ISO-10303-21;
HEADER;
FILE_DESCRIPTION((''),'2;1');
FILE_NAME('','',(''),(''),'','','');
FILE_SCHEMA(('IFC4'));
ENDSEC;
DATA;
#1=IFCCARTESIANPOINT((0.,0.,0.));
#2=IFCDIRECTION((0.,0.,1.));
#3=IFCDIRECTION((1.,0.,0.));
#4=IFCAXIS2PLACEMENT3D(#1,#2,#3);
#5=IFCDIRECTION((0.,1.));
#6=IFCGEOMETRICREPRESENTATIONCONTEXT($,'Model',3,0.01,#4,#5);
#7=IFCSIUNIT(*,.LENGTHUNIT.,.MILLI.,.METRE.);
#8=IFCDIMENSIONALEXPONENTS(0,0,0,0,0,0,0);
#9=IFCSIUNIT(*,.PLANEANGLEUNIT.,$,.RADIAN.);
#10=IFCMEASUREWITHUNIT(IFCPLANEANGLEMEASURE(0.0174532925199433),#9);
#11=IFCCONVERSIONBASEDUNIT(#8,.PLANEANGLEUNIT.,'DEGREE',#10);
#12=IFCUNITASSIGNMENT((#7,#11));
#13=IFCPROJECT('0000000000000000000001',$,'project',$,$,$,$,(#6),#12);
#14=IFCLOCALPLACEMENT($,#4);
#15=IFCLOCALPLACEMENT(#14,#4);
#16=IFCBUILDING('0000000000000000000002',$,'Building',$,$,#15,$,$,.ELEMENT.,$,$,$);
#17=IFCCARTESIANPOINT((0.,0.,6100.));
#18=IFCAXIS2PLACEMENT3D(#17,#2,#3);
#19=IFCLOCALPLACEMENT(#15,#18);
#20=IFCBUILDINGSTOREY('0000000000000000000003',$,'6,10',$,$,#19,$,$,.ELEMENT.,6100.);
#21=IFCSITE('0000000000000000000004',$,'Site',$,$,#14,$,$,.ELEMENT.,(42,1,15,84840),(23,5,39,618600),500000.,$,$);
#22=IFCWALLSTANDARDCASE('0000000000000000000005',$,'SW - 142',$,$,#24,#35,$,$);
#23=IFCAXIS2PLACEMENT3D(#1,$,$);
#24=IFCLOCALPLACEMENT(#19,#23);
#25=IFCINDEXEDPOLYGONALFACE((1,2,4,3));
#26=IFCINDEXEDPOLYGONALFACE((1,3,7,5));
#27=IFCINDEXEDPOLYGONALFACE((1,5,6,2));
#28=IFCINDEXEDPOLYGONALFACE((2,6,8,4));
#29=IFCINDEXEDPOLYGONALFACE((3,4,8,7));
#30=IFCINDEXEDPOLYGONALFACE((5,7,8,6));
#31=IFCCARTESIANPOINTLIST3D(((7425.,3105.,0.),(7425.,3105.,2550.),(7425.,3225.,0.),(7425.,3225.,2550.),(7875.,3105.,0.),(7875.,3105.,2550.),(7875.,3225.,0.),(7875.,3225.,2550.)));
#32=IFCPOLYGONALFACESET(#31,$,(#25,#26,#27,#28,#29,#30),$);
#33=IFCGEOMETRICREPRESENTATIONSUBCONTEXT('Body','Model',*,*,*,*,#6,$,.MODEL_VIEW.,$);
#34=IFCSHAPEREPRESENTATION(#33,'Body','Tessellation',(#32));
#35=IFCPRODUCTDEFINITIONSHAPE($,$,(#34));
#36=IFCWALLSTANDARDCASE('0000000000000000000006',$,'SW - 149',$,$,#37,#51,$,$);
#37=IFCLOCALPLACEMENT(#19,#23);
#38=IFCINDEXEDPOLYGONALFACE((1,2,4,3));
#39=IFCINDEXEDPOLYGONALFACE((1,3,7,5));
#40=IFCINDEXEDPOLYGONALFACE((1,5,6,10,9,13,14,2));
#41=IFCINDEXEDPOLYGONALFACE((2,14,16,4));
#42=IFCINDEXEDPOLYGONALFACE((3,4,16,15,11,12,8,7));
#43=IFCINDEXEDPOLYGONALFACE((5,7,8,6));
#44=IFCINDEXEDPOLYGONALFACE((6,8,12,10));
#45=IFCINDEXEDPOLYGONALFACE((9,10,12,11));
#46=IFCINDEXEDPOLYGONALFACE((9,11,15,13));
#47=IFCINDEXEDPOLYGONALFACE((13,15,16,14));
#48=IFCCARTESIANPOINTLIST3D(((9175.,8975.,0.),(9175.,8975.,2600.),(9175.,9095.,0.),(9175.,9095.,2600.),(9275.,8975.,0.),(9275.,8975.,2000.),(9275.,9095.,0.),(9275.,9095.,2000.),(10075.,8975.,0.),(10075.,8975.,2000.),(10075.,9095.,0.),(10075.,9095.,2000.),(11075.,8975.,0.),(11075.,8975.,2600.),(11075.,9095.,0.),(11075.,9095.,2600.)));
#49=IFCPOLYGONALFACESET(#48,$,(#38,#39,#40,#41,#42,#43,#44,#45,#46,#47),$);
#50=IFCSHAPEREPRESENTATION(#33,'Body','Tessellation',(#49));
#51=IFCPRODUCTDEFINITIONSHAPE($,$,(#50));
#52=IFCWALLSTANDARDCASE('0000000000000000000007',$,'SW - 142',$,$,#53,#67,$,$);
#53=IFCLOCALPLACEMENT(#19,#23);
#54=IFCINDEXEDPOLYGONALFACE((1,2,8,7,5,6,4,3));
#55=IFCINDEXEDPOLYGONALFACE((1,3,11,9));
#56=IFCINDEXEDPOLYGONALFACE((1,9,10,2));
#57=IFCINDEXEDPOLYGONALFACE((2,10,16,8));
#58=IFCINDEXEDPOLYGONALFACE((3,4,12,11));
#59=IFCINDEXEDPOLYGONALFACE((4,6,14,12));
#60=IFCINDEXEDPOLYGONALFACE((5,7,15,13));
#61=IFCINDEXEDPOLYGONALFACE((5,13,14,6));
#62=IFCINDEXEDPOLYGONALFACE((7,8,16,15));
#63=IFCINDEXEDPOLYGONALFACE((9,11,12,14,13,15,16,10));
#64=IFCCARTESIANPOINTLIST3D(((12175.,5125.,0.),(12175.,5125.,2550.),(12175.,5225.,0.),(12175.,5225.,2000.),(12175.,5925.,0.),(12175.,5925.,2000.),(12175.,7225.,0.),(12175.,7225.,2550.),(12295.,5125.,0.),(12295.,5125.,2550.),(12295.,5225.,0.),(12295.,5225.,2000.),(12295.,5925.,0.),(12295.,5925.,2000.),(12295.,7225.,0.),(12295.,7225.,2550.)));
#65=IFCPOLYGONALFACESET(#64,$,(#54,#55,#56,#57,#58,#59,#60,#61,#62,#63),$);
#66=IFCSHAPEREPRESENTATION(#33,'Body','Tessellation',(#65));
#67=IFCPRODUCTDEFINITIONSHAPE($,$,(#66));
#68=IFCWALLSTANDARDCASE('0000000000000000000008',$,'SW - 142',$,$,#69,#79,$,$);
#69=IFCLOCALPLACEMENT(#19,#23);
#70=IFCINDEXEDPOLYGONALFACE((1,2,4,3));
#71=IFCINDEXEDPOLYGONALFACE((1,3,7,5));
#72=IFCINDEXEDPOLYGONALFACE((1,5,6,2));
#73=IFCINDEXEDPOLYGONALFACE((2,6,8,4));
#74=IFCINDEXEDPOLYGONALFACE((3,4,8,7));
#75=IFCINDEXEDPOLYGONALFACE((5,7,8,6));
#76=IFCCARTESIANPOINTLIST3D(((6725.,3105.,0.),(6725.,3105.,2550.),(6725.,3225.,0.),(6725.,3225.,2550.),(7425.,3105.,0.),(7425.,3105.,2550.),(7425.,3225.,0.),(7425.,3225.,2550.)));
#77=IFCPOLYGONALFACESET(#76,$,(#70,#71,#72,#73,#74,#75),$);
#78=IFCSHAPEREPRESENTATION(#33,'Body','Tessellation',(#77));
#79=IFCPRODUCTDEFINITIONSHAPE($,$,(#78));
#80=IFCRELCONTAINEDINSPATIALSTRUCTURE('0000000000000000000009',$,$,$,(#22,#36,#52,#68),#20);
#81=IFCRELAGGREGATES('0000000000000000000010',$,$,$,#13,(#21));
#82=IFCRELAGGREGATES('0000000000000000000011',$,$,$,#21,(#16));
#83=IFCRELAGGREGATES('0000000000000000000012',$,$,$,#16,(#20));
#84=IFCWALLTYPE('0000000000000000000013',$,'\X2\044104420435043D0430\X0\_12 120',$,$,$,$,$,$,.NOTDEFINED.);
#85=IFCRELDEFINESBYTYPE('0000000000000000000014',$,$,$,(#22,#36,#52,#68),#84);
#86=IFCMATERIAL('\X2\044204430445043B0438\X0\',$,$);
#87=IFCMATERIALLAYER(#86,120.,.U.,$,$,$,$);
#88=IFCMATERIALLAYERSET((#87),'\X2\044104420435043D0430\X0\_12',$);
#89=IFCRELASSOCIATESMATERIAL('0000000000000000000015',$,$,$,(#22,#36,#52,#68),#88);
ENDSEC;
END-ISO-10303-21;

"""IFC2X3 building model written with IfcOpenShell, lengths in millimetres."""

from ifc_helpers import new_model, entity, si_unit, converted_unit, direction, frame, origin_with_axes, origin_2d_with_axis, place, context, subcontext, project, spatial, polyline, rectangle, outline, extrude, material, layer, layer_set, layer_usage, type_object, element, save


model = new_model("IFC2X3")

# Units and contexts
model_context = context("Model", 3, precision=0.01, world=origin_with_axes(), true_north=direction((0.0, 1.0)))
body_context = subcontext(model_context, "Body", "Model", "MODEL_VIEW")
ifc_project = project(units=[si_unit("LENGTHUNIT", "METRE", prefix="MILLI"), converted_unit("PLANEANGLEUNIT", "DEGREE", entity("IfcPlaneAngleMeasure", 0.0174532925199433), si_unit("PLANEANGLEUNIT", "RADIAN"), dimensions=[0, 0, 0, 0, 0, 0, 0])], contexts=[model_context])

# Site, building, storey
site_placement = place(None, origin_with_axes())
site = spatial("IfcSite", under=ifc_project, at=site_placement, Name="Site", CompositionType="ELEMENT", RefLatitude=(42, 1, 15, 84840), RefLongitude=(23, 5, 39, 618600), RefElevation=500000.0)
building_placement = place(site_placement, origin_with_axes())
building = spatial("IfcBuilding", under=site, at=building_placement, Name="Building", CompositionType="ELEMENT")
storey_placement = place(building_placement, frame((0.0, 0.0, 6100.0), z_axis=(0.0, 0.0, 1.0), x_axis=(1.0, 0.0, 0.0)))
storey = spatial("IfcBuildingStorey", under=building, at=storey_placement, Name="6,10", CompositionType="ELEMENT", Elevation=6100.0)

# Shared definitions
ifc_material_1 = material(Name="тухли")

# Shared definitions
ifc_layer_1 = layer(ifc_material_1, 120.0, ventilated="UNKNOWN")
ifc_layer_set_1 = layer_set([ifc_layer_1], Name="стена_12")
wall_type_1 = type_object("IfcWallType", Name="стена_12 120", PredefinedType="NOTDEFINED")

# Wall
ifc_layer_usage_1 = layer_usage(ifc_layer_set_1, "AXIS2", "POSITIVE", -60.0)
wall_1_placement = place(storey_placement, frame((7875.0, 3165.0, 0.0), z_axis=(0.0, 0.0, 1.0), x_axis=(-1.0, 0.0, 0.0)))
element("IfcWallStandardCase", 1, at=wall_1_placement, inside=storey, type_object=wall_type_1, material=ifc_layer_usage_1, Name="SW - 142", context=body_context, shape_type="SweptSolid", body=[
    extrude(outline(polyline([(0.0, -60.0), (450.0, -60.0), (450.0, 60.0), (0.0, 60.0), (0.0, -60.0)])), origin_with_axes(), (0.0, 0.0, 1.0), 2550.0),
])

# Walls, openings
ifc_layer_usage_2 = layer_usage(ifc_layer_set_1, "AXIS2", "NEGATIVE", 0.0)
wall_2_placement = place(storey_placement, frame((11075.0, 8975.0, 0.0), z_axis=(0.0, 0.0, 1.0), x_axis=(-1.0, 0.0, 0.0)))
wall_2 = element("IfcWallStandardCase", 2, at=wall_2_placement, inside=storey, type_object=wall_type_1, material=ifc_layer_usage_2, Name="SW - 149", context=body_context, shape_type="SweptSolid", body=[
    extrude(outline(polyline([(0.0, -120.0), (1900.0, -120.0), (1900.0, 0.0), (0.0, 0.0), (0.0, -120.0)])), origin_with_axes(), (0.0, 0.0, 1.0), 2600.0),
])
opening_1_placement = place(wall_2_placement, frame((1400.0, 0.0, 0.0), z_axis=(0.0, 0.0, 1.0), x_axis=(1.0, 0.0, 0.0)))
element("IfcOpeningElement", 3, at=opening_1_placement, cuts=wall_2, context=body_context, shape_type="SweptSolid", body=[
    extrude(rectangle(XDim=800.0, YDim=2000.0, at=origin_2d_with_axis()), frame((0.0, 120.0, 1000.0), z_axis=(0.0, 1.0, 0.0), x_axis=(1.0, 0.0, 0.0)), (0.0, 0.0, -1.0), 360.0),
])
ifc_layer_usage_3 = layer_usage(ifc_layer_set_1, "AXIS2", "POSITIVE", -60.0)
wall_3_placement = place(storey_placement, frame((12235.0, 7225.0, 0.0), z_axis=(0.0, 0.0, 1.0), x_axis=(0.0, -1.0, 0.0)))
wall_3 = element("IfcWallStandardCase", 4, at=wall_3_placement, inside=storey, type_object=wall_type_1, material=ifc_layer_usage_3, Name="SW - 142", context=body_context, shape_type="SweptSolid", body=[
    extrude(outline(polyline([(0.0, -60.0), (2100.0, -60.0), (2100.0, 60.0), (0.0, 60.0), (0.0, -60.0)])), origin_with_axes(), (0.0, 0.0, 1.0), 2550.0),
])
opening_2_placement = place(wall_3_placement, frame((1650.0, 0.0, 0.0), z_axis=(0.0, 0.0, 1.0), x_axis=(1.0, 0.0, 0.0)))
element("IfcOpeningElement", 5, at=opening_2_placement, cuts=wall_3, context=body_context, shape_type="SweptSolid", body=[
    extrude(rectangle(XDim=700.0, YDim=2000.0, at=origin_2d_with_axis()), frame((0.0, -120.0, 1000.0), z_axis=(0.0, 1.0, 0.0), x_axis=(1.0, 0.0, 0.0)), (0.0, 0.0, 1.0), 360.0),
])

# Wall
ifc_layer_usage_4 = layer_usage(ifc_layer_set_1, "AXIS2", "NEGATIVE", 60.0)
wall_4_placement = place(storey_placement, frame((6725.0, 3165.0, 0.0), z_axis=(0.0, 0.0, 1.0), x_axis=(1.0, 0.0, 0.0)))
element("IfcWallStandardCase", 6, at=wall_4_placement, inside=storey, type_object=wall_type_1, material=ifc_layer_usage_4, Name="SW - 142", context=body_context, shape_type="SweptSolid", body=[
    extrude(outline(polyline([(0.0, -60.0), (700.0, -60.0), (700.0, 60.0), (0.0, 60.0), (0.0, -60.0)])), origin_with_axes(), (0.0, 0.0, 1.0), 2550.0),
])

save(model, "model.ifc")
